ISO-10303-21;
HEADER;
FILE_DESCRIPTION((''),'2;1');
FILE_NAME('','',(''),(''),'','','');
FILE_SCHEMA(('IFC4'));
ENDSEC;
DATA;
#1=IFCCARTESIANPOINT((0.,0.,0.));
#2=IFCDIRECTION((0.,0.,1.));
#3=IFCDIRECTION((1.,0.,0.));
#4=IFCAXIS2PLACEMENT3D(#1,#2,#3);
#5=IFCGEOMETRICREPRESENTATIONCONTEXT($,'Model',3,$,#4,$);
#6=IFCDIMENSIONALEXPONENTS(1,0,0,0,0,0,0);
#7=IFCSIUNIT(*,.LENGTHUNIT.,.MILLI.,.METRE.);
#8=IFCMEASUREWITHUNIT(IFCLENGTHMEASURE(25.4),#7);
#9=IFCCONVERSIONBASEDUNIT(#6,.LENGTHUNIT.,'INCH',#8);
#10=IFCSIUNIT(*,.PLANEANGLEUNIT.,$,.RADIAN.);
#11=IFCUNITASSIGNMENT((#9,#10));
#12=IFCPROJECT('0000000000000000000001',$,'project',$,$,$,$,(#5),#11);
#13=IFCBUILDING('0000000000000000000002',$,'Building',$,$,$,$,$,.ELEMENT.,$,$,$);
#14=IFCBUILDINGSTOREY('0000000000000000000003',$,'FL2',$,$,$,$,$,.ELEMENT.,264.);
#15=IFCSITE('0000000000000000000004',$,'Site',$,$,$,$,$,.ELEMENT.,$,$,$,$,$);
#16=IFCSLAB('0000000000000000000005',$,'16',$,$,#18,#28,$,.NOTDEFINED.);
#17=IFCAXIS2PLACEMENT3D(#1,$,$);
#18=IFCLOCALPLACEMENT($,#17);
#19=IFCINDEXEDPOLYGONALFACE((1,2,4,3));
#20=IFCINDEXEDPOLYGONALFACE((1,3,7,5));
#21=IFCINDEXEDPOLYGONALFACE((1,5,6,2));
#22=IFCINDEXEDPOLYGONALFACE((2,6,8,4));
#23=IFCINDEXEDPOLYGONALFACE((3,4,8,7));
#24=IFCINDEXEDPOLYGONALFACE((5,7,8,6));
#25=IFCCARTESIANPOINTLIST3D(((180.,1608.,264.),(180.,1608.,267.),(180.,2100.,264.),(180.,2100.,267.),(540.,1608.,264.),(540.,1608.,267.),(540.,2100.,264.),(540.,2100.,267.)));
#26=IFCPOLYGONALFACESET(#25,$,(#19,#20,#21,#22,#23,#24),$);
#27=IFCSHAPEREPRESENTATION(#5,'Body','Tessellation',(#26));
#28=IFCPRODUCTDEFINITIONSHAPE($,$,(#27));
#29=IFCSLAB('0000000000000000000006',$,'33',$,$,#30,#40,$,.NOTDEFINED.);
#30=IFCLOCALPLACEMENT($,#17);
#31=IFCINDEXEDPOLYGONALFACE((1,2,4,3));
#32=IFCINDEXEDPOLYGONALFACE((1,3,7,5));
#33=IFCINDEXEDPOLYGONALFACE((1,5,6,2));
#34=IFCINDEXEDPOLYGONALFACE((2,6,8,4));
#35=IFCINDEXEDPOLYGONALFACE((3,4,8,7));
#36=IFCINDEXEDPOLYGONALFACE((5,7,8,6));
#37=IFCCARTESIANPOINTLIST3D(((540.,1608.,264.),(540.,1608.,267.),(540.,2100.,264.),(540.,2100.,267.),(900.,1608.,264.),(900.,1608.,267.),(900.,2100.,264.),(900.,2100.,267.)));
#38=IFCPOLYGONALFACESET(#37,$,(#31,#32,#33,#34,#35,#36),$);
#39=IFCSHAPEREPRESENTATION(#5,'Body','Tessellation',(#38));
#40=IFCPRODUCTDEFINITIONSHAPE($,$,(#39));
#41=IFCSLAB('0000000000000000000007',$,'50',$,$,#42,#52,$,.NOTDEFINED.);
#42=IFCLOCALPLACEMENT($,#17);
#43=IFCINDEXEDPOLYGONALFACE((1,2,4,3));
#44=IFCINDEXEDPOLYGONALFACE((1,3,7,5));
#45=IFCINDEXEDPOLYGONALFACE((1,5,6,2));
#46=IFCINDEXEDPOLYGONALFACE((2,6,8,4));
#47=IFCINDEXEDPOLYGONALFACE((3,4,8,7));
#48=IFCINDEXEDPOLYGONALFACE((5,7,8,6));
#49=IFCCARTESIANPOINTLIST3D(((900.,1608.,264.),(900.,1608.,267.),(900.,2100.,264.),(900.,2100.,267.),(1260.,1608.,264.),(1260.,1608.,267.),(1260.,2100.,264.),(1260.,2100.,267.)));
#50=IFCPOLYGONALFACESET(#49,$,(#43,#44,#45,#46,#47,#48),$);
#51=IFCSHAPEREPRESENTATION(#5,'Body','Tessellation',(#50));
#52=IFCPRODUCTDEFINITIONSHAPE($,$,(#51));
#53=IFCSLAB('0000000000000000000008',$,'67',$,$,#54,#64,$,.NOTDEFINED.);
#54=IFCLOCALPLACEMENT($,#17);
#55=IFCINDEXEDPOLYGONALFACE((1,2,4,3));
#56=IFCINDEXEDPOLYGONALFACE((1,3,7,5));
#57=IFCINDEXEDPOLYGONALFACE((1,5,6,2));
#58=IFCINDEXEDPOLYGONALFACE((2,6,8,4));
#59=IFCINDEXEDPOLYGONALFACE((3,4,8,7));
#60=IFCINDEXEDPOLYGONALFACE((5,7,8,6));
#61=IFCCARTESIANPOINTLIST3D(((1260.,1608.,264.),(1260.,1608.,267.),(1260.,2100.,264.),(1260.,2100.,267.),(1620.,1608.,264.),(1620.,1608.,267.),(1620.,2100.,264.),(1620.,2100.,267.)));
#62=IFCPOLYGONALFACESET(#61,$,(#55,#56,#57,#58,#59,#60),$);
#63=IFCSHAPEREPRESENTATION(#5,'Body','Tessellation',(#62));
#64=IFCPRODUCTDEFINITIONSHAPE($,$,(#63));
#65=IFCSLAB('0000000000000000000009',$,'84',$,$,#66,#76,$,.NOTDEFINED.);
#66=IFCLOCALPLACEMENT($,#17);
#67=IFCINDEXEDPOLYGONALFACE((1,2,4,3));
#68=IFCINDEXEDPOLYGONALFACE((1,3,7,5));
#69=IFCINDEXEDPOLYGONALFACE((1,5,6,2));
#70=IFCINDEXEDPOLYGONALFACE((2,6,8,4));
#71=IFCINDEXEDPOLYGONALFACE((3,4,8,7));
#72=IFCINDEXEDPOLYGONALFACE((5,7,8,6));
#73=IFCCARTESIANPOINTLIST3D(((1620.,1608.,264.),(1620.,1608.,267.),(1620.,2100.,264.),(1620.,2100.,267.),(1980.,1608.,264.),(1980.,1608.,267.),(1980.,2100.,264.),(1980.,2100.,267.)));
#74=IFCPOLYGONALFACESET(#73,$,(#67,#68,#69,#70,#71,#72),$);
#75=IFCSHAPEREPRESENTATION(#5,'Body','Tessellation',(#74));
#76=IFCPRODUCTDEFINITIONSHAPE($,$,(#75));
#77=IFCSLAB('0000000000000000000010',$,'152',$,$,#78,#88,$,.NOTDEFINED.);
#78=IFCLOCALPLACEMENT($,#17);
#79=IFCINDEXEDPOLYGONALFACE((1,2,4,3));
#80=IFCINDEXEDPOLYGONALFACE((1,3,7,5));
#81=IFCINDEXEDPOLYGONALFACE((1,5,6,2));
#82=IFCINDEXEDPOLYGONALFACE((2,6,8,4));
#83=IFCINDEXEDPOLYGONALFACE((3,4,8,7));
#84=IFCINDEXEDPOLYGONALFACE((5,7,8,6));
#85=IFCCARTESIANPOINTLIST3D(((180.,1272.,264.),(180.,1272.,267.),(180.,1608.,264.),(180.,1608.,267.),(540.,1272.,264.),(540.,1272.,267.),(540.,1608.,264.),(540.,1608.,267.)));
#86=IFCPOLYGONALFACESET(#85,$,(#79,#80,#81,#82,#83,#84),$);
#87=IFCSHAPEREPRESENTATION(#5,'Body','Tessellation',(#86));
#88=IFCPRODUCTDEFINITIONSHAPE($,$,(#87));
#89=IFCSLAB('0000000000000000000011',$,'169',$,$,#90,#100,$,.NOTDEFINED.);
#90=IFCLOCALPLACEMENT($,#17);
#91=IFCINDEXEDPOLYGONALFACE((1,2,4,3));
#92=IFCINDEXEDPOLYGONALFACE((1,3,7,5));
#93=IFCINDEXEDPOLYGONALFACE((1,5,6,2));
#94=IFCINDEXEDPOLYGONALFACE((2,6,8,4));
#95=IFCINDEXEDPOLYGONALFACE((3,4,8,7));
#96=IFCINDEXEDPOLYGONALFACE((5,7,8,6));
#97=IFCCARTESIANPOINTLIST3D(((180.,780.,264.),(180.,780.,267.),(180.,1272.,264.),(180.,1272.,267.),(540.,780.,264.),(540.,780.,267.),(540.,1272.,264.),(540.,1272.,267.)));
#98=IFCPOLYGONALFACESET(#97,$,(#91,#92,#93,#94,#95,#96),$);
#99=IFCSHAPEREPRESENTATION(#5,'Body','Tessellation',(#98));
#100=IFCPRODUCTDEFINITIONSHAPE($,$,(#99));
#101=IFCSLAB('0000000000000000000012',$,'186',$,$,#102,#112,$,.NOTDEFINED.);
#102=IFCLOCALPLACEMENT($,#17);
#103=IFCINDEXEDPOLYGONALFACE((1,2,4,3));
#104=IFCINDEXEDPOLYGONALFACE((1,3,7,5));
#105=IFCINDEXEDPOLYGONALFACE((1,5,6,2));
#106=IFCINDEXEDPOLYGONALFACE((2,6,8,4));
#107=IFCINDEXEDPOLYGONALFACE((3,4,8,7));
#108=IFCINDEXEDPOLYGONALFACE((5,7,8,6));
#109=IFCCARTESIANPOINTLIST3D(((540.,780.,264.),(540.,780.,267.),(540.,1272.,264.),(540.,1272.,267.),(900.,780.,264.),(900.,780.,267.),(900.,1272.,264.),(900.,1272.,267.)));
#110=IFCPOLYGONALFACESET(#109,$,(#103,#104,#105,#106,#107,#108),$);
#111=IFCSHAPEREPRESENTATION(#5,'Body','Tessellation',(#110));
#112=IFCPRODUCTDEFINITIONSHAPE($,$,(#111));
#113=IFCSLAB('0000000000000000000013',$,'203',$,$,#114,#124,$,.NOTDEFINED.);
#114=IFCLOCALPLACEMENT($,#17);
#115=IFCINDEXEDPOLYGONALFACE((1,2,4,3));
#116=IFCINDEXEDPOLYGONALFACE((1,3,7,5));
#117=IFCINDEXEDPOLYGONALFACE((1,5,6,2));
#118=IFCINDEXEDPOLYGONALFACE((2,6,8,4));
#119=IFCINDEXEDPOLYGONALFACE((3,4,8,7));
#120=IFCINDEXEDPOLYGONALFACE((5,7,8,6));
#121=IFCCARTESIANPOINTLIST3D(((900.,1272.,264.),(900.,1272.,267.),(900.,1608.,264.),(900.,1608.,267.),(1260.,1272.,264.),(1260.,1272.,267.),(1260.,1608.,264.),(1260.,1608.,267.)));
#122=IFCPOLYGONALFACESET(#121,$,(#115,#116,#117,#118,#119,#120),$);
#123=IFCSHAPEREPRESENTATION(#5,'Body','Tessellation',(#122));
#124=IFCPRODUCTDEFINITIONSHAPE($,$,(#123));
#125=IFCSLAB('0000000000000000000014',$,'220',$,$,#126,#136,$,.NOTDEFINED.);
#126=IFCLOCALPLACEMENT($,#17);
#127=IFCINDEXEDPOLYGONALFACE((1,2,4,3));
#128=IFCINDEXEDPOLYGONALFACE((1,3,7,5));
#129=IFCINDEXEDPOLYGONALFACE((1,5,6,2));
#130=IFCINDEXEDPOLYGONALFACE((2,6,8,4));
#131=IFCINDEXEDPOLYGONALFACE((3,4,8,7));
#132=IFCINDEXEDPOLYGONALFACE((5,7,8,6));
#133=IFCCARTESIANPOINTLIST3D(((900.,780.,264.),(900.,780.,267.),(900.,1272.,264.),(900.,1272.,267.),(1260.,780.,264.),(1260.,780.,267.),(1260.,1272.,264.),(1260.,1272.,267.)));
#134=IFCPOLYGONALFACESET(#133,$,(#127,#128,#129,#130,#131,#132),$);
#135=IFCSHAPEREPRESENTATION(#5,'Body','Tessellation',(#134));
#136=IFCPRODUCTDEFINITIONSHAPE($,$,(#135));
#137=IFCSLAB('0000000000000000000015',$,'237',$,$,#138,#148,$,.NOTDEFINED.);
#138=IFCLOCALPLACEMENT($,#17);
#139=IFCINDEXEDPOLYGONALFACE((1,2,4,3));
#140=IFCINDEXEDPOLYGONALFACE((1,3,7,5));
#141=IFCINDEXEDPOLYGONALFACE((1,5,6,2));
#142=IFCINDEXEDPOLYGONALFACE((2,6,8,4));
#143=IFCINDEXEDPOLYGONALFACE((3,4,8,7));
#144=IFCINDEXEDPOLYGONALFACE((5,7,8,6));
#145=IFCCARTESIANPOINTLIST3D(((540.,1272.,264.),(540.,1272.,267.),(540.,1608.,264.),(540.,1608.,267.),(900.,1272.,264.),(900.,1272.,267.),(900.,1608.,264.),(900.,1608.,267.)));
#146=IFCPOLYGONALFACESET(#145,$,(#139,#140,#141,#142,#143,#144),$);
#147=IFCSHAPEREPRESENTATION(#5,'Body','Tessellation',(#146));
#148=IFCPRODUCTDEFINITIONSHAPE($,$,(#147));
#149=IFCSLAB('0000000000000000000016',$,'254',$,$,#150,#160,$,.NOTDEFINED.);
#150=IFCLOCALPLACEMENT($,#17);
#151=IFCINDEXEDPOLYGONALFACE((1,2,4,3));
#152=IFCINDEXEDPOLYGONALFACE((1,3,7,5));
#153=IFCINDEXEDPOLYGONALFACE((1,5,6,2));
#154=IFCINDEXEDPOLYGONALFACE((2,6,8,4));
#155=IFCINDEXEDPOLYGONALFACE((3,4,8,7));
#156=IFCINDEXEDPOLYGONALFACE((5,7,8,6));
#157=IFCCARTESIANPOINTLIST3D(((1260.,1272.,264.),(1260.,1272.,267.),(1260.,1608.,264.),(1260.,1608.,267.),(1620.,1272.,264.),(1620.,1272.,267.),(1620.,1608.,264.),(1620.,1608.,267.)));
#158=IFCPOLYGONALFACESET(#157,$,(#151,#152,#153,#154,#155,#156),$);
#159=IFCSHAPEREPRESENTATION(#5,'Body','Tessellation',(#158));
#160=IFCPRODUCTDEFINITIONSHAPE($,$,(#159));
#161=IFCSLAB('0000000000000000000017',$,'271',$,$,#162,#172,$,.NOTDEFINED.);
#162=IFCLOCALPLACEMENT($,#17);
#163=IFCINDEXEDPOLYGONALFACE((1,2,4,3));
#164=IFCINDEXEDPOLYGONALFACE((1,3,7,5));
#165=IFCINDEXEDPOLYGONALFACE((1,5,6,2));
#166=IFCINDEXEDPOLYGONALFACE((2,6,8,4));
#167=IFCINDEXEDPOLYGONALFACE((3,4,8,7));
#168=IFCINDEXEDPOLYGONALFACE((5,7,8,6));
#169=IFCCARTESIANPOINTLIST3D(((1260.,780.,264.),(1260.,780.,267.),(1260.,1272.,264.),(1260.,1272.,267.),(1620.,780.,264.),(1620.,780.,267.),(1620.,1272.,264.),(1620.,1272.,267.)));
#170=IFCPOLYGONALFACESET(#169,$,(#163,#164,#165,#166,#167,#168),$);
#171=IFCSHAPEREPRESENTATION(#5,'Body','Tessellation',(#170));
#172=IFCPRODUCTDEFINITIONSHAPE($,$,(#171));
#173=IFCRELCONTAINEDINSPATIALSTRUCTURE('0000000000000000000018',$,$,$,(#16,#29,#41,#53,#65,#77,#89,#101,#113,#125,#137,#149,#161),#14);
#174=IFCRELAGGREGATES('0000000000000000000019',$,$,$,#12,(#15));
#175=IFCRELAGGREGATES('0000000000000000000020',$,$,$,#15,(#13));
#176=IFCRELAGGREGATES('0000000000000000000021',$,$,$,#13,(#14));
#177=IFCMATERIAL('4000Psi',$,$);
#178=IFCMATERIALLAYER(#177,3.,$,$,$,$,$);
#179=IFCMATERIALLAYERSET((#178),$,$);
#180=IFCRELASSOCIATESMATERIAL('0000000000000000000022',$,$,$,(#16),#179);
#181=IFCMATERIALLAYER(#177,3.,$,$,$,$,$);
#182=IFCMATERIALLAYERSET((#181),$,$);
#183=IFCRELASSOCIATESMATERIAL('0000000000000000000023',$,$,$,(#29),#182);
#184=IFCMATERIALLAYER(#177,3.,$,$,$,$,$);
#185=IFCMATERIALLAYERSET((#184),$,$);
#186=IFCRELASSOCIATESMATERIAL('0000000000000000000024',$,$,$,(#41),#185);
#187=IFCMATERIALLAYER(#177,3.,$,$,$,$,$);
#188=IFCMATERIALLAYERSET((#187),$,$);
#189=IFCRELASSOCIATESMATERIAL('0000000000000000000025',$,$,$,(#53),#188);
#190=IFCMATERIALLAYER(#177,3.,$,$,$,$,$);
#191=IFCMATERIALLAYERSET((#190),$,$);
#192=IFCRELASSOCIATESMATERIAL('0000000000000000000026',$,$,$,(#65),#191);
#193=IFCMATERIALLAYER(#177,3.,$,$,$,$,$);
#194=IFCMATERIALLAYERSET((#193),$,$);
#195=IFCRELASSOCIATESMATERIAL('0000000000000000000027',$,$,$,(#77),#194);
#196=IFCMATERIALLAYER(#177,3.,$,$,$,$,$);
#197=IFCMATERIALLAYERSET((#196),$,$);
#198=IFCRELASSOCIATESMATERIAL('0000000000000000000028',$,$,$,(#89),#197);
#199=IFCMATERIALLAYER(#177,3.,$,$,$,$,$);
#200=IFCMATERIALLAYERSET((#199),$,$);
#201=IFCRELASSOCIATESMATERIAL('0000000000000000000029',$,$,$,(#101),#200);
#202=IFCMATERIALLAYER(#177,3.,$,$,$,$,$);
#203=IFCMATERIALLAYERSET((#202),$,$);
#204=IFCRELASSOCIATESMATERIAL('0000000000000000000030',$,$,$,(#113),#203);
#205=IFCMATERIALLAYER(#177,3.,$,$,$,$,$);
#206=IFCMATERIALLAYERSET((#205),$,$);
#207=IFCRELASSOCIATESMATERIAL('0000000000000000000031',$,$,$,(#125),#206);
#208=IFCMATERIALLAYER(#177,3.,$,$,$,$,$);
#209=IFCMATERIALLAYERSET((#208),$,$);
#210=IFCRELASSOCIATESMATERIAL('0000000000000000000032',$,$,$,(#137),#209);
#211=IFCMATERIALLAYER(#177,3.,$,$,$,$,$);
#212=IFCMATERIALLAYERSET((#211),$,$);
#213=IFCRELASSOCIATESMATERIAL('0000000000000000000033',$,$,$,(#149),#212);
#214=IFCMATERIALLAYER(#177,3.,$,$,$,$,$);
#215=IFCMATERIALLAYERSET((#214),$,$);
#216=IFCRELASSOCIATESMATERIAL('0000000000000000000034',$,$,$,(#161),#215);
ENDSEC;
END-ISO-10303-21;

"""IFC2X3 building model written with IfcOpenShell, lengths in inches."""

from ifc_helpers import new_model, entity, si_unit, converted_unit, frame, origin_with_axes, place, context, project, spatial, polyline, outline, extrude, material, layer, layer_set, layer_usage, element, save


model = new_model("IFC2X3")

# Units and contexts
model_context = context("Model", 3, world=origin_with_axes())
ifc_project = project(units=[converted_unit("LENGTHUNIT", "INCH", entity("IfcLengthMeasure", 25.4), si_unit("LENGTHUNIT", "METRE", prefix="MILLI"), dimensions=[1, 0, 0, 0, 0, 0, 0]), si_unit("PLANEANGLEUNIT", "RADIAN")], contexts=[model_context])

# Site, building, storey
site = spatial("IfcSite", under=ifc_project, Name="Site", CompositionType="ELEMENT")
building = spatial("IfcBuilding", under=site, Name="Building", CompositionType="ELEMENT")
storey = spatial("IfcBuildingStorey", under=building, Name="FL2", CompositionType="ELEMENT", Elevation=264.0)

# Slabs
ifc_material_1 = material(Name="4000Psi")
ifc_layer_1 = layer(ifc_material_1, 3.0)
ifc_layer_set_1 = layer_set([ifc_layer_1])
ifc_layer_usage_1 = layer_usage(ifc_layer_set_1, "AXIS2", "POSITIVE", -3.0)
slab_1_placement = place(None, frame((180.0, 1608.0, 264.0), z_axis=(0.0, 0.0, 1.0), x_axis=(1.0, 0.0, 0.0)))
element("IfcSlab", 1, at=slab_1_placement, inside=storey, material=ifc_layer_usage_1, Name="16", PredefinedType="NOTDEFINED", context=model_context, shape_type="SweptSolid", body=[
    extrude(outline(polyline([(0.0, 0.0), (360.0, 0.0), (360.0, 492.0), (0.0, 492.0), (0.0, 0.0)])), origin_with_axes(), (0.0, 0.0, 1.0), 3.0),
])
ifc_layer_2 = layer(ifc_material_1, 3.0)
ifc_layer_set_2 = layer_set([ifc_layer_2])
ifc_layer_usage_2 = layer_usage(ifc_layer_set_2, "AXIS2", "POSITIVE", -3.0)
slab_2_placement = place(None, frame((540.0, 1608.0, 264.0), z_axis=(0.0, 0.0, 1.0), x_axis=(1.0, 0.0, 0.0)))
element("IfcSlab", 2, at=slab_2_placement, inside=storey, material=ifc_layer_usage_2, Name="33", PredefinedType="NOTDEFINED", context=model_context, shape_type="SweptSolid", body=[
    extrude(outline(polyline([(0.0, 0.0), (360.0, 0.0), (360.0, 492.0), (0.0, 492.0), (0.0, 0.0)])), origin_with_axes(), (0.0, 0.0, 1.0), 3.0),
])
ifc_layer_3 = layer(ifc_material_1, 3.0)
ifc_layer_set_3 = layer_set([ifc_layer_3])
ifc_layer_usage_3 = layer_usage(ifc_layer_set_3, "AXIS2", "POSITIVE", -3.0)
slab_3_placement = place(None, frame((900.0, 1608.0, 264.0), z_axis=(0.0, 0.0, 1.0), x_axis=(1.0, 0.0, 0.0)))
element("IfcSlab", 3, at=slab_3_placement, inside=storey, material=ifc_layer_usage_3, Name="50", PredefinedType="NOTDEFINED", context=model_context, shape_type="SweptSolid", body=[
    extrude(outline(polyline([(0.0, 0.0), (360.0, 0.0), (360.0, 492.0), (0.0, 492.0), (0.0, 0.0)])), origin_with_axes(), (0.0, 0.0, 1.0), 3.0),
])
ifc_layer_4 = layer(ifc_material_1, 3.0)
ifc_layer_set_4 = layer_set([ifc_layer_4])
ifc_layer_usage_4 = layer_usage(ifc_layer_set_4, "AXIS2", "POSITIVE", -3.0)
slab_4_placement = place(None, frame((1260.0, 1608.0, 264.0), z_axis=(0.0, 0.0, 1.0), x_axis=(1.0, 0.0, 0.0)))
element("IfcSlab", 4, at=slab_4_placement, inside=storey, material=ifc_layer_usage_4, Name="67", PredefinedType="NOTDEFINED", context=model_context, shape_type="SweptSolid", body=[
    extrude(outline(polyline([(0.0, 0.0), (360.0, 0.0), (360.0, 492.0), (0.0, 492.0), (0.0, 0.0)])), origin_with_axes(), (0.0, 0.0, 1.0), 3.0),
])
ifc_layer_5 = layer(ifc_material_1, 3.0)
ifc_layer_set_5 = layer_set([ifc_layer_5])
ifc_layer_usage_5 = layer_usage(ifc_layer_set_5, "AXIS2", "POSITIVE", -3.0)
slab_5_placement = place(None, frame((1620.0, 1608.0, 264.0), z_axis=(0.0, 0.0, 1.0), x_axis=(1.0, 0.0, 0.0)))
element("IfcSlab", 5, at=slab_5_placement, inside=storey, material=ifc_layer_usage_5, Name="84", PredefinedType="NOTDEFINED", context=model_context, shape_type="SweptSolid", body=[
    extrude(outline(polyline([(0.0, 0.0), (360.0, 0.0), (360.0, 492.0), (0.0, 492.0), (0.0, 0.0)])), origin_with_axes(), (0.0, 0.0, 1.0), 3.0),
])
ifc_layer_6 = layer(ifc_material_1, 3.0)
ifc_layer_set_6 = layer_set([ifc_layer_6])
ifc_layer_usage_6 = layer_usage(ifc_layer_set_6, "AXIS2", "POSITIVE", -3.0)
slab_6_placement = place(None, frame((180.0, 1272.0, 264.0), z_axis=(0.0, 0.0, 1.0), x_axis=(1.0, 0.0, 0.0)))
element("IfcSlab", 6, at=slab_6_placement, inside=storey, material=ifc_layer_usage_6, Name="152", PredefinedType="NOTDEFINED", context=model_context, shape_type="SweptSolid", body=[
    extrude(outline(polyline([(0.0, 0.0), (360.0, 0.0), (360.0, 336.0), (0.0, 336.0), (0.0, 0.0)])), origin_with_axes(), (0.0, 0.0, 1.0), 3.0),
])
ifc_layer_7 = layer(ifc_material_1, 3.0)
ifc_layer_set_7 = layer_set([ifc_layer_7])
ifc_layer_usage_7 = layer_usage(ifc_layer_set_7, "AXIS2", "POSITIVE", -3.0)
slab_7_placement = place(None, frame((180.0, 780.0, 264.0), z_axis=(0.0, 0.0, 1.0), x_axis=(1.0, 0.0, 0.0)))
element("IfcSlab", 7, at=slab_7_placement, inside=storey, material=ifc_layer_usage_7, Name="169", PredefinedType="NOTDEFINED", context=model_context, shape_type="SweptSolid", body=[
    extrude(outline(polyline([(0.0, 0.0), (360.0, 0.0), (360.0, 492.0), (0.0, 492.0), (0.0, 0.0)])), origin_with_axes(), (0.0, 0.0, 1.0), 3.0),
])
ifc_layer_8 = layer(ifc_material_1, 3.0)
ifc_layer_set_8 = layer_set([ifc_layer_8])
ifc_layer_usage_8 = layer_usage(ifc_layer_set_8, "AXIS2", "POSITIVE", -3.0)
slab_8_placement = place(None, frame((540.0, 780.0, 264.0), z_axis=(0.0, 0.0, 1.0), x_axis=(1.0, 0.0, 0.0)))
element("IfcSlab", 8, at=slab_8_placement, inside=storey, material=ifc_layer_usage_8, Name="186", PredefinedType="NOTDEFINED", context=model_context, shape_type="SweptSolid", body=[
    extrude(outline(polyline([(0.0, 0.0), (360.0, 0.0), (360.0, 492.0), (0.0, 492.0), (0.0, 0.0)])), origin_with_axes(), (0.0, 0.0, 1.0), 3.0),
])
ifc_layer_9 = layer(ifc_material_1, 3.0)
ifc_layer_set_9 = layer_set([ifc_layer_9])
ifc_layer_usage_9 = layer_usage(ifc_layer_set_9, "AXIS2", "POSITIVE", -3.0)
slab_9_placement = place(None, frame((900.0, 1272.0, 264.0), z_axis=(0.0, 0.0, 1.0), x_axis=(1.0, 0.0, 0.0)))
element("IfcSlab", 9, at=slab_9_placement, inside=storey, material=ifc_layer_usage_9, Name="203", PredefinedType="NOTDEFINED", context=model_context, shape_type="SweptSolid", body=[
    extrude(outline(polyline([(0.0, 0.0), (360.0, 0.0), (360.0, 336.0), (0.0, 336.0), (0.0, 0.0)])), origin_with_axes(), (0.0, 0.0, 1.0), 3.0),
])
ifc_layer_10 = layer(ifc_material_1, 3.0)
ifc_layer_set_10 = layer_set([ifc_layer_10])
ifc_layer_usage_10 = layer_usage(ifc_layer_set_10, "AXIS2", "POSITIVE", -3.0)
slab_10_placement = place(None, frame((900.0, 780.0, 264.0), z_axis=(0.0, 0.0, 1.0), x_axis=(1.0, 0.0, 0.0)))
element("IfcSlab", 10, at=slab_10_placement, inside=storey, material=ifc_layer_usage_10, Name="220", PredefinedType="NOTDEFINED", context=model_context, shape_type="SweptSolid", body=[
    extrude(outline(polyline([(0.0, 0.0), (360.0, 0.0), (360.0, 492.0), (0.0, 492.0), (0.0, 0.0)])), origin_with_axes(), (0.0, 0.0, 1.0), 3.0),
])
ifc_layer_11 = layer(ifc_material_1, 3.0)
ifc_layer_set_11 = layer_set([ifc_layer_11])
ifc_layer_usage_11 = layer_usage(ifc_layer_set_11, "AXIS2", "POSITIVE", -3.0)
slab_11_placement = place(None, frame((540.0, 1272.0, 264.0), z_axis=(0.0, 0.0, 1.0), x_axis=(1.0, 0.0, 0.0)))
element("IfcSlab", 11, at=slab_11_placement, inside=storey, material=ifc_layer_usage_11, Name="237", PredefinedType="NOTDEFINED", context=model_context, shape_type="SweptSolid", body=[
    extrude(outline(polyline([(0.0, 0.0), (360.0, 0.0), (360.0, 336.0), (0.0, 336.0), (0.0, 0.0)])), origin_with_axes(), (0.0, 0.0, 1.0), 3.0),
])
ifc_layer_12 = layer(ifc_material_1, 3.0)
ifc_layer_set_12 = layer_set([ifc_layer_12])
ifc_layer_usage_12 = layer_usage(ifc_layer_set_12, "AXIS2", "POSITIVE", -3.0)
slab_12_placement = place(None, frame((1260.0, 1272.0, 264.0), z_axis=(0.0, 0.0, 1.0), x_axis=(1.0, 0.0, 0.0)))
element("IfcSlab", 12, at=slab_12_placement, inside=storey, material=ifc_layer_usage_12, Name="254", PredefinedType="NOTDEFINED", context=model_context, shape_type="SweptSolid", body=[
    extrude(outline(polyline([(0.0, 0.0), (360.0, 0.0), (360.0, 336.0), (0.0, 336.0), (0.0, 0.0)])), origin_with_axes(), (0.0, 0.0, 1.0), 3.0),
])
ifc_layer_13 = layer(ifc_material_1, 3.0)
ifc_layer_set_13 = layer_set([ifc_layer_13])
ifc_layer_usage_13 = layer_usage(ifc_layer_set_13, "AXIS2", "POSITIVE", -3.0)
slab_13_placement = place(None, frame((1260.0, 780.0, 264.0), z_axis=(0.0, 0.0, 1.0), x_axis=(1.0, 0.0, 0.0)))
element("IfcSlab", 13, at=slab_13_placement, inside=storey, material=ifc_layer_usage_13, Name="271", PredefinedType="NOTDEFINED", context=model_context, shape_type="SweptSolid", body=[
    extrude(outline(polyline([(0.0, 0.0), (360.0, 0.0), (360.0, 492.0), (0.0, 492.0), (0.0, 0.0)])), origin_with_axes(), (0.0, 0.0, 1.0), 3.0),
])

save(model, "model.ifc")
